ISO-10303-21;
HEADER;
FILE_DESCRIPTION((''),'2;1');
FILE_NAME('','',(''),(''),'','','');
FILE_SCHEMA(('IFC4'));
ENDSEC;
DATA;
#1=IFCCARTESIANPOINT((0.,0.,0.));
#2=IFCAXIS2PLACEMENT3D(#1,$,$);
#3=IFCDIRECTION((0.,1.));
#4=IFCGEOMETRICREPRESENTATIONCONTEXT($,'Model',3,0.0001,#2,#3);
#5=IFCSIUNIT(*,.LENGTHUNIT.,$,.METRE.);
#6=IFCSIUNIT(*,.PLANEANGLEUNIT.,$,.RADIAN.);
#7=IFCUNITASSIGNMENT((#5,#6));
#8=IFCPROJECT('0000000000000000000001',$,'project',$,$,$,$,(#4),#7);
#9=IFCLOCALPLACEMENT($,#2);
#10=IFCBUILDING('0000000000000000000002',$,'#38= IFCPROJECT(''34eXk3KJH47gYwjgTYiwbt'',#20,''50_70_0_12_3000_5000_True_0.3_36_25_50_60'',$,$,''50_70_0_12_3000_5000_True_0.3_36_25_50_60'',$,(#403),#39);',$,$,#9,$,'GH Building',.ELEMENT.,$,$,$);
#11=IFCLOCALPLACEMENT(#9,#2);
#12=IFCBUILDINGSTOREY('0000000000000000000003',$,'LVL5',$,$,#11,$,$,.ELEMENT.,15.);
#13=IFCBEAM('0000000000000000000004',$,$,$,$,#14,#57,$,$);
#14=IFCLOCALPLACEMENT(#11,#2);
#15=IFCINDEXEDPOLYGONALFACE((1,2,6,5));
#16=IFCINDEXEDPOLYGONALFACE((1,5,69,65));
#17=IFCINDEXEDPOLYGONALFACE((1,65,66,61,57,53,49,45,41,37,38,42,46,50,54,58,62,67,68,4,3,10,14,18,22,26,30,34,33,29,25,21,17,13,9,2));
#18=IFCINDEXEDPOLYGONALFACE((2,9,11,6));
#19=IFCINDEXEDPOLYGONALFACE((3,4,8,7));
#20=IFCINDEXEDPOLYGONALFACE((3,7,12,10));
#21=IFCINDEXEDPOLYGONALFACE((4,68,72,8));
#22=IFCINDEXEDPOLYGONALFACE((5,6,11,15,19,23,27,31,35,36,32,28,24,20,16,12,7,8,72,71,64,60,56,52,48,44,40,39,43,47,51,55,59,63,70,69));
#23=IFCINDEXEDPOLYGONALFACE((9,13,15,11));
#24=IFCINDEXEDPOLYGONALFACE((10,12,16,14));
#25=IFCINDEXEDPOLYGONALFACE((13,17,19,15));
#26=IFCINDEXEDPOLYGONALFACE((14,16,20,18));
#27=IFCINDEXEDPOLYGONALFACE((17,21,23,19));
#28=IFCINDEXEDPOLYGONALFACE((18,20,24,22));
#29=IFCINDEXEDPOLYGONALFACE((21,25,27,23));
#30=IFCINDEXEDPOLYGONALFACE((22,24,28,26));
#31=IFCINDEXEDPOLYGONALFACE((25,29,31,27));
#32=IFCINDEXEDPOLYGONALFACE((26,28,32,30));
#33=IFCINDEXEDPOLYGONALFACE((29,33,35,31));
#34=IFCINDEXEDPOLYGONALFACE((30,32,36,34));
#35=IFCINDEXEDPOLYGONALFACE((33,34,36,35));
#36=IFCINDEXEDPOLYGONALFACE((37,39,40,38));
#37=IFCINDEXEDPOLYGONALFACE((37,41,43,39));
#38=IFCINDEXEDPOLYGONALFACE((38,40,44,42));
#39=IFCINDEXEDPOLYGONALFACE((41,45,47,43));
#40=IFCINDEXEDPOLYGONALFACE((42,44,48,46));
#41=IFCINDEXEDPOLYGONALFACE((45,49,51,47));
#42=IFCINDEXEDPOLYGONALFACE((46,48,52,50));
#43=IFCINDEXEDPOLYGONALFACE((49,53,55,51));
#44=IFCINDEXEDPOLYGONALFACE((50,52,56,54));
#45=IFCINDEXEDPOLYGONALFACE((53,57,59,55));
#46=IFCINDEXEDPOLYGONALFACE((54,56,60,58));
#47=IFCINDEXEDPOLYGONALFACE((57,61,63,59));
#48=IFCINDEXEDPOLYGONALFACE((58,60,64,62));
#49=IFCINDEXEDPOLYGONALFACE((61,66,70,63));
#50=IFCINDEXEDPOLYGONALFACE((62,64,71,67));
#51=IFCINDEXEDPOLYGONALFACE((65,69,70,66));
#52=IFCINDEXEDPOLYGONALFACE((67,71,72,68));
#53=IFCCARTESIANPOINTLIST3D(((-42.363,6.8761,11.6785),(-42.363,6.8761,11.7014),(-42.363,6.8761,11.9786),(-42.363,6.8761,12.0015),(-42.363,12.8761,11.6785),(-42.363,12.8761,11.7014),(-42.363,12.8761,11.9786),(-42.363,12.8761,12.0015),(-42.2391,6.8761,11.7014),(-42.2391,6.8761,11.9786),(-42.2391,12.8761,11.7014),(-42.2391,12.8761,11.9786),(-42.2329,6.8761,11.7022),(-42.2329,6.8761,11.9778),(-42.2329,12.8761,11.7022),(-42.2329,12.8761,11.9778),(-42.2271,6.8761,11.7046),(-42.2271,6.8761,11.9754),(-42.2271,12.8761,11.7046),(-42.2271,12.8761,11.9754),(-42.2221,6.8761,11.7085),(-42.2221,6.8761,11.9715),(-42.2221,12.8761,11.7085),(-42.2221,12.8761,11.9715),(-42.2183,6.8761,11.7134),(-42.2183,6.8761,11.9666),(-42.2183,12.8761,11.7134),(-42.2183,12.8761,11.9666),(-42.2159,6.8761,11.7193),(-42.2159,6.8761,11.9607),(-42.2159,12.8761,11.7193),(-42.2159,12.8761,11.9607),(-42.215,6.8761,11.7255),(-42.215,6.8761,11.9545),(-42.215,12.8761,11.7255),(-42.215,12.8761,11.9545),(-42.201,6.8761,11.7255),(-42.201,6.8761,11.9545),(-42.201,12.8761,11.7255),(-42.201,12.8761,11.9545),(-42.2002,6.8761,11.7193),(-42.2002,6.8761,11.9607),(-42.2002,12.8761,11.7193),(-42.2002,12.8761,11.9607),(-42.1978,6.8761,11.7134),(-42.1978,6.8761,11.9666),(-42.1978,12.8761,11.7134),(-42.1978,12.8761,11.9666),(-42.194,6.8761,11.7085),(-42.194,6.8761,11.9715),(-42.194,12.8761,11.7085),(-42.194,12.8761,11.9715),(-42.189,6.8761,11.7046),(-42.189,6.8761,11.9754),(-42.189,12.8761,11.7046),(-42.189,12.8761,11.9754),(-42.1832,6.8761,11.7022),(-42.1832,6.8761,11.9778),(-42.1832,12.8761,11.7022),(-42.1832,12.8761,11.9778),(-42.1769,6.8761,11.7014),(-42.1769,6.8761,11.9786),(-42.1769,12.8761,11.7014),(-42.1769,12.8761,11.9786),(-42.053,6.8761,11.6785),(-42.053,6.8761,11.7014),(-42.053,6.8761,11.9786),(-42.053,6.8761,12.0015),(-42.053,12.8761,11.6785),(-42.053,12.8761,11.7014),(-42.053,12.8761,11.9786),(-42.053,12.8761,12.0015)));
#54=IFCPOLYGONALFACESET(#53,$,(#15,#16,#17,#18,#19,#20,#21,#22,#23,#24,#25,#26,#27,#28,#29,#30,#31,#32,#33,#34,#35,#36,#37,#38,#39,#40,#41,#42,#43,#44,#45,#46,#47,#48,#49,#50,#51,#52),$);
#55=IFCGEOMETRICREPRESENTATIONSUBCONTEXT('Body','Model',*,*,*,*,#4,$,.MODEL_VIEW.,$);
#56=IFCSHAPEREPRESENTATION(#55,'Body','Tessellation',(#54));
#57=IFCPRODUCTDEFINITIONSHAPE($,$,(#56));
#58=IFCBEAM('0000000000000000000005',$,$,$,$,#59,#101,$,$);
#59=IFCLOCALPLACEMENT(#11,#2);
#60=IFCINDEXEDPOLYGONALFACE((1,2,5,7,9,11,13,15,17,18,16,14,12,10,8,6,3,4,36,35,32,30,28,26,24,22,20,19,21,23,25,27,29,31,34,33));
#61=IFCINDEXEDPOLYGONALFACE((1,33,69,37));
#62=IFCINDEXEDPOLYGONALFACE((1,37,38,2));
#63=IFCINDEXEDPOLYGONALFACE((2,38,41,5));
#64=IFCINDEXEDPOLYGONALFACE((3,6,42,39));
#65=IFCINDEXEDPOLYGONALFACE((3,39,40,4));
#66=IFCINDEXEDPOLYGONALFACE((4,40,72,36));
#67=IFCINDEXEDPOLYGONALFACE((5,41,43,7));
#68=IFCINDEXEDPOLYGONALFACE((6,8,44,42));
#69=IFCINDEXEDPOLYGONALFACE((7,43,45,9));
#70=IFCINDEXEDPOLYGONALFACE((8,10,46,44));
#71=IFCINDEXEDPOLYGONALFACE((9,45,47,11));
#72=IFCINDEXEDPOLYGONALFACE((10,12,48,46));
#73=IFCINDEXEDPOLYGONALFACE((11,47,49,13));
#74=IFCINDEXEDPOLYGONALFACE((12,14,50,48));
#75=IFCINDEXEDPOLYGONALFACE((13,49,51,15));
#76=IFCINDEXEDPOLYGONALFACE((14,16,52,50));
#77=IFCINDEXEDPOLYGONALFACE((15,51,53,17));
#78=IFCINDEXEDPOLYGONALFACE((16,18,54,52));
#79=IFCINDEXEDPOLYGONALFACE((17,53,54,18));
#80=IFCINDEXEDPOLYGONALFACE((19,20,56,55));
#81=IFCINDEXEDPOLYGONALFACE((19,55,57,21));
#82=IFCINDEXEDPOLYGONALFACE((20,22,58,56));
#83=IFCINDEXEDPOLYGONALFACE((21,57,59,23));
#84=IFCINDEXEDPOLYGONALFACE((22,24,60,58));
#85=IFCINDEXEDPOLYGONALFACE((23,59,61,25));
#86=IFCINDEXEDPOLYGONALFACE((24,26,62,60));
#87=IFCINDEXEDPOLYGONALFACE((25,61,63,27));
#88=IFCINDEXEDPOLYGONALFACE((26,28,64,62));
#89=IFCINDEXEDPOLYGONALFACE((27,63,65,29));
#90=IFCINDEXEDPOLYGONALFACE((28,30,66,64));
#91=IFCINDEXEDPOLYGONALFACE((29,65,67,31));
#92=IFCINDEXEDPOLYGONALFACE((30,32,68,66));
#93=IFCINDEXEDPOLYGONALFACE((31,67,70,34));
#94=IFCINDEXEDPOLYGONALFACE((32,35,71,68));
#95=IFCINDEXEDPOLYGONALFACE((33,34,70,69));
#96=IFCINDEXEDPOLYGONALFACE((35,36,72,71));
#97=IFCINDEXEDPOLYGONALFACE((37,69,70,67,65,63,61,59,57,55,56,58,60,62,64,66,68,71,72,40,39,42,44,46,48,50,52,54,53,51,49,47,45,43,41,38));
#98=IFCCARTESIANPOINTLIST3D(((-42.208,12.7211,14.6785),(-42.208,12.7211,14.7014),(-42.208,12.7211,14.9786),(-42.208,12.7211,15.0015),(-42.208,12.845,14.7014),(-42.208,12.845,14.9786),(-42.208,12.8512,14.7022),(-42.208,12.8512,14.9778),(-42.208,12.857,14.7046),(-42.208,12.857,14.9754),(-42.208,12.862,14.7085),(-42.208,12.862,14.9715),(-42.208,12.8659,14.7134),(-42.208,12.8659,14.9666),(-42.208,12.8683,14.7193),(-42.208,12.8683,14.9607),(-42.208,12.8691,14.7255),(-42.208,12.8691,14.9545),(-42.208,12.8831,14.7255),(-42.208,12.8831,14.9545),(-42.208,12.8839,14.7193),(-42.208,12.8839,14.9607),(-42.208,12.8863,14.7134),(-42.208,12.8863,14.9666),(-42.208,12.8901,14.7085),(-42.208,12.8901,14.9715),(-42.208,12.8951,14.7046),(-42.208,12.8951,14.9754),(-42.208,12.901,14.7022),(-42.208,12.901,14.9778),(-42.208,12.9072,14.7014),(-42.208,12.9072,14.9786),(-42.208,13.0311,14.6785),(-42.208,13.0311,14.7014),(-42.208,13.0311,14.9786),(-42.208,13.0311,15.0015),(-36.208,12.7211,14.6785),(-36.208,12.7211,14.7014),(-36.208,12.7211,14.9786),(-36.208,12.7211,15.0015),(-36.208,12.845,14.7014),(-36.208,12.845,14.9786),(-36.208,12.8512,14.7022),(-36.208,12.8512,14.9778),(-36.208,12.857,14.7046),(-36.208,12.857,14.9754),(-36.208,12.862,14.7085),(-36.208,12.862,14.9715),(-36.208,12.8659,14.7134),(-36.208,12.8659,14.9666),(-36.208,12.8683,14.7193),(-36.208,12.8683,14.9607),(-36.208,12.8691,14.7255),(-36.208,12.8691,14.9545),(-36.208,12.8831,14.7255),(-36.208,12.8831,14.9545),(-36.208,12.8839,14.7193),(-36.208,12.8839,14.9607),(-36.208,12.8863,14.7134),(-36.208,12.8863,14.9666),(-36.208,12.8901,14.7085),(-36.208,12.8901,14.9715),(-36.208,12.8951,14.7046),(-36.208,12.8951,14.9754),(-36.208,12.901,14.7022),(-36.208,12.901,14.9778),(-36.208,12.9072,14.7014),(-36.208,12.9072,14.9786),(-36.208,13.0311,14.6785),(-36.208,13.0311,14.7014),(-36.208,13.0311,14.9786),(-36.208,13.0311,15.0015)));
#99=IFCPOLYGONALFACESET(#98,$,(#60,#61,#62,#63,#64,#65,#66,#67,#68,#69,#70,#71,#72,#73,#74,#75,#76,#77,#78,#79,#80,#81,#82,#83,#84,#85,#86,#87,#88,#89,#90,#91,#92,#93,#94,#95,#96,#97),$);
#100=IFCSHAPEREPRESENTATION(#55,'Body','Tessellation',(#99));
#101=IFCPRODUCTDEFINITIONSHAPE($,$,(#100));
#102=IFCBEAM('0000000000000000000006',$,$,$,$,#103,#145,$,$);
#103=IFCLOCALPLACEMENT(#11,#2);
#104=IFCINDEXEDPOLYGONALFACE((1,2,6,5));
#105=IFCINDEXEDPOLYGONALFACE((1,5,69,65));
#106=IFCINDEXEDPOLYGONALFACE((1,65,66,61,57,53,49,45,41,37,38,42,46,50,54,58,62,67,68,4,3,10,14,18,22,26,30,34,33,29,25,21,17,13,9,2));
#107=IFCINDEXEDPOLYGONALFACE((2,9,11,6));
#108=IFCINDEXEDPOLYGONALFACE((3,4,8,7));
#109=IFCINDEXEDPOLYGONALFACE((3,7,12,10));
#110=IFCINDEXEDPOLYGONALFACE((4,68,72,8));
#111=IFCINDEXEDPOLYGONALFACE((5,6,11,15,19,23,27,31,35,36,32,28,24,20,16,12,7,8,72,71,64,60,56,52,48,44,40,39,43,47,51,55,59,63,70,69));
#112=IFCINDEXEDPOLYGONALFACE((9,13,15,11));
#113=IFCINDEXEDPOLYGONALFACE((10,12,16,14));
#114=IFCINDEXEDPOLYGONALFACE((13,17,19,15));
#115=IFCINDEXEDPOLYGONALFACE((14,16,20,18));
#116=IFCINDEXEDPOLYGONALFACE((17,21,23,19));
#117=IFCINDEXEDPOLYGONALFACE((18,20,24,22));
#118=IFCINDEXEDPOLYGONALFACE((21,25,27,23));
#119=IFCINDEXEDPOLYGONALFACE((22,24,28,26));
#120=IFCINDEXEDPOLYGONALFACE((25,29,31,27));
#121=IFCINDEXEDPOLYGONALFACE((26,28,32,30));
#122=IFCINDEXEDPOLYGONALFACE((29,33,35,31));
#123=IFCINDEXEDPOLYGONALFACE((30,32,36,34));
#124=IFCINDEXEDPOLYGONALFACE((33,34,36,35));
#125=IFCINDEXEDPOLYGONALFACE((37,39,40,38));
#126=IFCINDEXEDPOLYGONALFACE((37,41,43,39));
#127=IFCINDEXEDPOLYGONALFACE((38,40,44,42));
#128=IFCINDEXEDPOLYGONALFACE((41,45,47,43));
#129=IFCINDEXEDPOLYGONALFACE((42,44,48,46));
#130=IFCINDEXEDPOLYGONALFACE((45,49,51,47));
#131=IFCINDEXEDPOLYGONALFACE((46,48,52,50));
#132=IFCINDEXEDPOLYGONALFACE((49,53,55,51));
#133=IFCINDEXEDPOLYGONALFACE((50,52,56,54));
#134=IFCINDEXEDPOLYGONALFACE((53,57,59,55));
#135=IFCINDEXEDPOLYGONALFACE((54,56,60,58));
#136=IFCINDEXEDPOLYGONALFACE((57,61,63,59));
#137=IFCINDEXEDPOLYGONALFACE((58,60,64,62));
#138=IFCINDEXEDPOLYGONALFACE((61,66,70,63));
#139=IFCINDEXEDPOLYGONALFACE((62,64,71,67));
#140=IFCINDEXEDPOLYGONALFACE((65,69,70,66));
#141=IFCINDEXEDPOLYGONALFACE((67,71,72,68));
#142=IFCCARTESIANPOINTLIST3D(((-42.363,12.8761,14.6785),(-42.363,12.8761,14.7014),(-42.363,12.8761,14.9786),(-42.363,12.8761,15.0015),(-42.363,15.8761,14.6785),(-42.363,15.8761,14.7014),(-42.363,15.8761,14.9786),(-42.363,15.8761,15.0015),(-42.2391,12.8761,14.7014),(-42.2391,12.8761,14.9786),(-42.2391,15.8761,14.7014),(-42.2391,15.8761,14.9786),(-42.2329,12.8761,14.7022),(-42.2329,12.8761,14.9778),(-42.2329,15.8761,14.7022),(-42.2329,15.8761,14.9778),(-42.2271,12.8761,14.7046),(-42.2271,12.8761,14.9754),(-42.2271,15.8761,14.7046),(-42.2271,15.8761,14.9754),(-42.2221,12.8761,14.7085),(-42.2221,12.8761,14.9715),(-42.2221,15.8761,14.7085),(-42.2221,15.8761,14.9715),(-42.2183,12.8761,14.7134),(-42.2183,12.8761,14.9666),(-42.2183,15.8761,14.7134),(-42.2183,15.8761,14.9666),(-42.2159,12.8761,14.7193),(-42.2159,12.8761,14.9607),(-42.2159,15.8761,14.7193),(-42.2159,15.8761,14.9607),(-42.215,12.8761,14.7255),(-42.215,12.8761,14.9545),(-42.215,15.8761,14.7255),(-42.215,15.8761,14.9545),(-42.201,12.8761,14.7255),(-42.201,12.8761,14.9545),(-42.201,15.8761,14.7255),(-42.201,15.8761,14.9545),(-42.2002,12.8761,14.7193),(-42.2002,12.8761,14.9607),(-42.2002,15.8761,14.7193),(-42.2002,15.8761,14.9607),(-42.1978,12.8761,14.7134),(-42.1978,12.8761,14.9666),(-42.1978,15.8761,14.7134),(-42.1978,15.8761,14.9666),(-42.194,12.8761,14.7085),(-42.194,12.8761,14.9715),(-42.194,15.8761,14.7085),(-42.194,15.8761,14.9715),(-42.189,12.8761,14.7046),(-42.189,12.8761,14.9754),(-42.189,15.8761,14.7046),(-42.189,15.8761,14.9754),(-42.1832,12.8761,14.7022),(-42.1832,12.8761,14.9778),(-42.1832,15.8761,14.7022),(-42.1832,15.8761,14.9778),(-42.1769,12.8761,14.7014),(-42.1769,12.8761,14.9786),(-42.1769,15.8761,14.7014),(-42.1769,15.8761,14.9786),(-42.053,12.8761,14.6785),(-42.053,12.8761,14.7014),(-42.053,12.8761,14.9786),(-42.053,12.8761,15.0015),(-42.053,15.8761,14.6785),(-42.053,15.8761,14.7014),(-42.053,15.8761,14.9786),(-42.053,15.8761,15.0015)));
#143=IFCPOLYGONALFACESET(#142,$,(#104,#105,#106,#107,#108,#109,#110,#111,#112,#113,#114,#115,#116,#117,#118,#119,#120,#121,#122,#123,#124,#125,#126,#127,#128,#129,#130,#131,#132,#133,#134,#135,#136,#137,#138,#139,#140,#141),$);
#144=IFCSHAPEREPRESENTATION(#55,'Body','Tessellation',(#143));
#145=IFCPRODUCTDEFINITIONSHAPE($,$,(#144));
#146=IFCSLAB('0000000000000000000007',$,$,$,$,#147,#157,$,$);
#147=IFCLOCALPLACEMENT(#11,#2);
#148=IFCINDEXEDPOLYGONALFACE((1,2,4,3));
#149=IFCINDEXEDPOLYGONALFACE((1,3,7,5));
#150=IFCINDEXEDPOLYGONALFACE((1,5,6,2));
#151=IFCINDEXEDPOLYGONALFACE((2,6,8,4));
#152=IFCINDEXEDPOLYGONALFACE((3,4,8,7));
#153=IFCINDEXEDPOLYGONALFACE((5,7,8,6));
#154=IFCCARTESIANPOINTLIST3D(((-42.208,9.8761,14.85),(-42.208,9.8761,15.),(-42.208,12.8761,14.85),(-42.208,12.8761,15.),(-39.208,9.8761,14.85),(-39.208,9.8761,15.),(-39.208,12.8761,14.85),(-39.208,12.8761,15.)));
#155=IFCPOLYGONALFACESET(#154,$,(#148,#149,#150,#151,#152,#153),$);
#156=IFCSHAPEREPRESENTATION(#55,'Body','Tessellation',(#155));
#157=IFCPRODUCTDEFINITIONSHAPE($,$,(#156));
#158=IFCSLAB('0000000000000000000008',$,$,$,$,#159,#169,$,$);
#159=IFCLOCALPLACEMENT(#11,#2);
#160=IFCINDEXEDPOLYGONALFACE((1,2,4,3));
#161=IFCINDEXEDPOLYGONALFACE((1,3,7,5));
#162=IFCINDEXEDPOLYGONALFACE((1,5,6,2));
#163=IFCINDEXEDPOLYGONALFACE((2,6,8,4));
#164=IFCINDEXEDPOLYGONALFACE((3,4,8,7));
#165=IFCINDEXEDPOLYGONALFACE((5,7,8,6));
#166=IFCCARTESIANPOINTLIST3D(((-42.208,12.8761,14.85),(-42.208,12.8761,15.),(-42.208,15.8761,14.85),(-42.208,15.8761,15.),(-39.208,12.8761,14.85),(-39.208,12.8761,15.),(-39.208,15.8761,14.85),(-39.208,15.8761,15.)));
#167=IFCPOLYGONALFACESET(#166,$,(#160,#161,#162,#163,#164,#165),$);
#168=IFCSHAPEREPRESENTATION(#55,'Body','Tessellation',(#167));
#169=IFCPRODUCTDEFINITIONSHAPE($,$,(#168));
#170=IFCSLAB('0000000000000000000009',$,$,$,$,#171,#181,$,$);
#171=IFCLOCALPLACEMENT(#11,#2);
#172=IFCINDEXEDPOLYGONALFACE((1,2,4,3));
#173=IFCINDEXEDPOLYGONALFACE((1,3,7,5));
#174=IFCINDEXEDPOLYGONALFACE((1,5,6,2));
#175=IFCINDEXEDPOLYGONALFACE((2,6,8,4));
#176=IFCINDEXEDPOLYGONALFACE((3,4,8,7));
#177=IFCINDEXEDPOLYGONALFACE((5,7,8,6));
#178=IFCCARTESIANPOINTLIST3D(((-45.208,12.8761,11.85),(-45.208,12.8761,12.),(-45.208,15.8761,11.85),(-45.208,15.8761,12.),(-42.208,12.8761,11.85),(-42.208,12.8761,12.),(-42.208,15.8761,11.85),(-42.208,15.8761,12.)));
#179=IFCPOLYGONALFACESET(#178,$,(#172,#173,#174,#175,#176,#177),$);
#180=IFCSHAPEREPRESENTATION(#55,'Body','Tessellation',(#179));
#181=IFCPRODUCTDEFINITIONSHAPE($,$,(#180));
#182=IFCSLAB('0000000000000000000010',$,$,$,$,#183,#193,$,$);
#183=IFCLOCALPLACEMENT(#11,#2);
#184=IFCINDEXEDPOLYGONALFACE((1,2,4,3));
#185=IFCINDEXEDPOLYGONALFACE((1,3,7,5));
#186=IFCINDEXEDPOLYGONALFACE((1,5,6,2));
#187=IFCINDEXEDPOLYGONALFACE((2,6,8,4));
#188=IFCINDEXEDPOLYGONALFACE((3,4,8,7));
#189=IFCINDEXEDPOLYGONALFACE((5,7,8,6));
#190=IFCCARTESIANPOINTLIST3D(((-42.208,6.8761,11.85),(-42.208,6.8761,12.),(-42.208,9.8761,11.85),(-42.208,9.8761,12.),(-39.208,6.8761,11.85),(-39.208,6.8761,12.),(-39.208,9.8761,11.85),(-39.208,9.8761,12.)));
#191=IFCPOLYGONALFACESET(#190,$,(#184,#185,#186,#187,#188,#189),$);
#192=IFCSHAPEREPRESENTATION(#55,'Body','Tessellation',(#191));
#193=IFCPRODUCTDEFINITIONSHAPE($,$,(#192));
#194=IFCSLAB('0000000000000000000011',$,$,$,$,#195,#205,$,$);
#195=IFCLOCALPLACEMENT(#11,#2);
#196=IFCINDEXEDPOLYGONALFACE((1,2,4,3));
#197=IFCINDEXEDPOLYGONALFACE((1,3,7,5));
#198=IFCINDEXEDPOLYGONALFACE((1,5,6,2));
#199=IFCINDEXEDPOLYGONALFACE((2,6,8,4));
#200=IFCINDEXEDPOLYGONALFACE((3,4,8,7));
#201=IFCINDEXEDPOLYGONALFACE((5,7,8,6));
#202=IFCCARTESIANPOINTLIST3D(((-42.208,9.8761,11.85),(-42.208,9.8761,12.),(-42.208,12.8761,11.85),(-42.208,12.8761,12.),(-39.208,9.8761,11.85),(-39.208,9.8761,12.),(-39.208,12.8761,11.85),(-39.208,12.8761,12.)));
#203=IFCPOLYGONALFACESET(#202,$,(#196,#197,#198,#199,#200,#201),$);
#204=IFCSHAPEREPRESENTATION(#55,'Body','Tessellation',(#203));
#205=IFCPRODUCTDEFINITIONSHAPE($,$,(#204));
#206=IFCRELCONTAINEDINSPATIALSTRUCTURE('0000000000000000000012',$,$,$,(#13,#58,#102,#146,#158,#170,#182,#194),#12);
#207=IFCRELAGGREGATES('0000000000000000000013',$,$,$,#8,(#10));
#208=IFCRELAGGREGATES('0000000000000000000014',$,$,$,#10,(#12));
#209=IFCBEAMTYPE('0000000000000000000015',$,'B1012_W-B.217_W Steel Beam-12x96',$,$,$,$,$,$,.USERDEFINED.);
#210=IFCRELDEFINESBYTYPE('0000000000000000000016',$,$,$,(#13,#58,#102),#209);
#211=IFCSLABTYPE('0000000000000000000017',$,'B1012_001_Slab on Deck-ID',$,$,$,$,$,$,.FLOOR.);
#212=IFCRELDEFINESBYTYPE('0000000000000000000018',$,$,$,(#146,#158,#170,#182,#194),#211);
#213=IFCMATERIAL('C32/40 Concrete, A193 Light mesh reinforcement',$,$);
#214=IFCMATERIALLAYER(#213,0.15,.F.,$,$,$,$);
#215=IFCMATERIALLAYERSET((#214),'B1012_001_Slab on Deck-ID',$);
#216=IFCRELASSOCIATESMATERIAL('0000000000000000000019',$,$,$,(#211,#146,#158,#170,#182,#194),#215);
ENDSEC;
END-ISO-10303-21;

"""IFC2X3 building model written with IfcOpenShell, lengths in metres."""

from ifc_helpers import new_model, si_unit, direction, frame, origin, origin_2d, place, context, subcontext, project, spatial, polyline, i_section, outline, extrude, material, layer, layer_set, layer_usage, type_object, element, save


model = new_model("IFC2X3")

# Units and contexts
model_context = context("Model", 3, precision=0.0001, world=origin(), true_north=direction((0.0, 1.0)))
body_context = subcontext(model_context, "Body", "Model", "MODEL_VIEW")
ifc_project = project(units=[si_unit("LENGTHUNIT", "METRE"), si_unit("PLANEANGLEUNIT", "RADIAN")], contexts=[model_context])

# Building, storey
building_placement = place(None, origin())
building = spatial("IfcBuilding", under=ifc_project, at=building_placement, Name="#38= IFCPROJECT('34eXk3KJH47gYwjgTYiwbt',#20,'50_70_0_12_3000_5000_True_0.3_36_25_50_60',$,$,'50_70_0_12_3000_5000_True_0.3_36_25_50_60',$,(#403),#39);", LongName="GH Building", CompositionType="ELEMENT")
storey_placement = place(building_placement, origin())
storey = spatial("IfcBuildingStorey", under=building, at=storey_placement, Name="LVL5", CompositionType="ELEMENT", Elevation=15.0)

# Beams
beam_type = type_object("IfcBeamType", Name="B1012_W-B.217_W Steel Beam-12x96", PredefinedType="USERDEFINED")
for number, where, z_axis, x_axis in (
    (1, (-42.208, 6.8761, 11.84), (0.0, 1.0, 0.0), (-1.0, 0.0, 0.0)),
    (2, (-42.208, 12.8761, 14.84), (1.0, 0.0, 0.0), (0.0, 1.0, 0.0)),
):
    element("IfcBeam", number, at=place(storey_placement, frame(where, z_axis=z_axis, x_axis=x_axis)), inside=storey, type_object=beam_type, context=body_context, shape_type="SweptSolid", body=[
        extrude(i_section(OverallWidth=0.31, OverallDepth=0.323, WebThickness=0.014, FlangeThickness=0.0229, FilletRadius=0.0241, at=origin_2d()), origin(), (0.0, 0.0, 1.0), 6.0),
    ])
beam_1_placement = place(storey_placement, frame((-42.208, 12.8761, 14.84), z_axis=(0.0, 1.0, 0.0), x_axis=(-1.0, 0.0, 0.0)))
element("IfcBeam", 3, at=beam_1_placement, inside=storey, type_object=beam_type, context=body_context, shape_type="SweptSolid", body=[
    extrude(i_section(OverallWidth=0.31, OverallDepth=0.323, WebThickness=0.014, FlangeThickness=0.0229, FilletRadius=0.0241, at=origin_2d()), origin(), (0.0, 0.0, 1.0), 3.0),
])

# Slabs
ifc_material_1 = material(Name="C32/40 Concrete, A193 Light mesh reinforcement")
ifc_layer_1 = layer(ifc_material_1, 0.15, ventilated=False)
ifc_layer_set_1 = layer_set([ifc_layer_1], Name="B1012_001_Slab on Deck-ID")
ifc_layer_usage_1 = layer_usage(ifc_layer_set_1, "AXIS3", "NEGATIVE", -0.15)
slab_type_1 = type_object("IfcSlabType", Name="B1012_001_Slab on Deck-ID", PredefinedType="FLOOR", material=ifc_layer_set_1)
slab_1_placement = place(storey_placement, frame((-40.708, 11.3761, 14.85)))
element("IfcSlab", 4, at=slab_1_placement, inside=storey, type_object=slab_type_1, material=ifc_layer_usage_1, context=body_context, shape_type="SweptSolid", body=[
    extrude(outline(polyline([(-1.5, -1.5), (-1.5, 1.5), (1.5, 1.5), (1.5, -1.5), (-1.5, -1.5)])), origin(), (0.0, 0.0, 1.0), 0.15),
])
ifc_layer_usage_2 = layer_usage(ifc_layer_set_1, "AXIS3", "NEGATIVE", -0.15)
slab_2_placement = place(storey_placement, frame((-40.708, 14.3761, 14.85)))
element("IfcSlab", 5, at=slab_2_placement, inside=storey, type_object=slab_type_1, material=ifc_layer_usage_2, context=body_context, shape_type="SweptSolid", body=[
    extrude(outline(polyline([(-1.5, -1.5), (-1.5, 1.5), (1.5, 1.5), (1.5, -1.5), (-1.5, -1.5)])), origin(), (0.0, 0.0, 1.0), 0.15),
])
ifc_layer_usage_3 = layer_usage(ifc_layer_set_1, "AXIS3", "NEGATIVE", -0.15)
slab_3_placement = place(storey_placement, frame((-43.708, 14.3761, 11.85)))
element("IfcSlab", 6, at=slab_3_placement, inside=storey, type_object=slab_type_1, material=ifc_layer_usage_3, context=body_context, shape_type="SweptSolid", body=[
    extrude(outline(polyline([(-1.5, 1.5), (1.5, 1.5), (1.5, -1.5), (-1.5, -1.5), (-1.5, 1.5)])), origin(), (0.0, 0.0, 1.0), 0.15),
])
ifc_layer_usage_4 = layer_usage(ifc_layer_set_1, "AXIS3", "NEGATIVE", -0.15)
slab_4_placement = place(storey_placement, frame((-40.708, 8.3761, 11.85)))
element("IfcSlab", 7, at=slab_4_placement, inside=storey, type_object=slab_type_1, material=ifc_layer_usage_4, context=body_context, shape_type="SweptSolid", body=[
    extrude(outline(polyline([(1.5, 1.5), (1.5, -1.5), (-1.5, -1.5), (-1.5, 1.5), (1.5, 1.5)])), origin(), (0.0, 0.0, 1.0), 0.15),
])
ifc_layer_usage_5 = layer_usage(ifc_layer_set_1, "AXIS3", "NEGATIVE", -0.15)
slab_5_placement = place(storey_placement, frame((-40.708, 11.3761, 11.85)))
element("IfcSlab", 8, at=slab_5_placement, inside=storey, type_object=slab_type_1, material=ifc_layer_usage_5, context=body_context, shape_type="SweptSolid", body=[
    extrude(outline(polyline([(-1.5, -1.5), (-1.5, 1.5), (1.5, 1.5), (1.5, -1.5), (-1.5, -1.5)])), origin(), (0.0, 0.0, 1.0), 0.15),
])

save(model, "model.ifc")
